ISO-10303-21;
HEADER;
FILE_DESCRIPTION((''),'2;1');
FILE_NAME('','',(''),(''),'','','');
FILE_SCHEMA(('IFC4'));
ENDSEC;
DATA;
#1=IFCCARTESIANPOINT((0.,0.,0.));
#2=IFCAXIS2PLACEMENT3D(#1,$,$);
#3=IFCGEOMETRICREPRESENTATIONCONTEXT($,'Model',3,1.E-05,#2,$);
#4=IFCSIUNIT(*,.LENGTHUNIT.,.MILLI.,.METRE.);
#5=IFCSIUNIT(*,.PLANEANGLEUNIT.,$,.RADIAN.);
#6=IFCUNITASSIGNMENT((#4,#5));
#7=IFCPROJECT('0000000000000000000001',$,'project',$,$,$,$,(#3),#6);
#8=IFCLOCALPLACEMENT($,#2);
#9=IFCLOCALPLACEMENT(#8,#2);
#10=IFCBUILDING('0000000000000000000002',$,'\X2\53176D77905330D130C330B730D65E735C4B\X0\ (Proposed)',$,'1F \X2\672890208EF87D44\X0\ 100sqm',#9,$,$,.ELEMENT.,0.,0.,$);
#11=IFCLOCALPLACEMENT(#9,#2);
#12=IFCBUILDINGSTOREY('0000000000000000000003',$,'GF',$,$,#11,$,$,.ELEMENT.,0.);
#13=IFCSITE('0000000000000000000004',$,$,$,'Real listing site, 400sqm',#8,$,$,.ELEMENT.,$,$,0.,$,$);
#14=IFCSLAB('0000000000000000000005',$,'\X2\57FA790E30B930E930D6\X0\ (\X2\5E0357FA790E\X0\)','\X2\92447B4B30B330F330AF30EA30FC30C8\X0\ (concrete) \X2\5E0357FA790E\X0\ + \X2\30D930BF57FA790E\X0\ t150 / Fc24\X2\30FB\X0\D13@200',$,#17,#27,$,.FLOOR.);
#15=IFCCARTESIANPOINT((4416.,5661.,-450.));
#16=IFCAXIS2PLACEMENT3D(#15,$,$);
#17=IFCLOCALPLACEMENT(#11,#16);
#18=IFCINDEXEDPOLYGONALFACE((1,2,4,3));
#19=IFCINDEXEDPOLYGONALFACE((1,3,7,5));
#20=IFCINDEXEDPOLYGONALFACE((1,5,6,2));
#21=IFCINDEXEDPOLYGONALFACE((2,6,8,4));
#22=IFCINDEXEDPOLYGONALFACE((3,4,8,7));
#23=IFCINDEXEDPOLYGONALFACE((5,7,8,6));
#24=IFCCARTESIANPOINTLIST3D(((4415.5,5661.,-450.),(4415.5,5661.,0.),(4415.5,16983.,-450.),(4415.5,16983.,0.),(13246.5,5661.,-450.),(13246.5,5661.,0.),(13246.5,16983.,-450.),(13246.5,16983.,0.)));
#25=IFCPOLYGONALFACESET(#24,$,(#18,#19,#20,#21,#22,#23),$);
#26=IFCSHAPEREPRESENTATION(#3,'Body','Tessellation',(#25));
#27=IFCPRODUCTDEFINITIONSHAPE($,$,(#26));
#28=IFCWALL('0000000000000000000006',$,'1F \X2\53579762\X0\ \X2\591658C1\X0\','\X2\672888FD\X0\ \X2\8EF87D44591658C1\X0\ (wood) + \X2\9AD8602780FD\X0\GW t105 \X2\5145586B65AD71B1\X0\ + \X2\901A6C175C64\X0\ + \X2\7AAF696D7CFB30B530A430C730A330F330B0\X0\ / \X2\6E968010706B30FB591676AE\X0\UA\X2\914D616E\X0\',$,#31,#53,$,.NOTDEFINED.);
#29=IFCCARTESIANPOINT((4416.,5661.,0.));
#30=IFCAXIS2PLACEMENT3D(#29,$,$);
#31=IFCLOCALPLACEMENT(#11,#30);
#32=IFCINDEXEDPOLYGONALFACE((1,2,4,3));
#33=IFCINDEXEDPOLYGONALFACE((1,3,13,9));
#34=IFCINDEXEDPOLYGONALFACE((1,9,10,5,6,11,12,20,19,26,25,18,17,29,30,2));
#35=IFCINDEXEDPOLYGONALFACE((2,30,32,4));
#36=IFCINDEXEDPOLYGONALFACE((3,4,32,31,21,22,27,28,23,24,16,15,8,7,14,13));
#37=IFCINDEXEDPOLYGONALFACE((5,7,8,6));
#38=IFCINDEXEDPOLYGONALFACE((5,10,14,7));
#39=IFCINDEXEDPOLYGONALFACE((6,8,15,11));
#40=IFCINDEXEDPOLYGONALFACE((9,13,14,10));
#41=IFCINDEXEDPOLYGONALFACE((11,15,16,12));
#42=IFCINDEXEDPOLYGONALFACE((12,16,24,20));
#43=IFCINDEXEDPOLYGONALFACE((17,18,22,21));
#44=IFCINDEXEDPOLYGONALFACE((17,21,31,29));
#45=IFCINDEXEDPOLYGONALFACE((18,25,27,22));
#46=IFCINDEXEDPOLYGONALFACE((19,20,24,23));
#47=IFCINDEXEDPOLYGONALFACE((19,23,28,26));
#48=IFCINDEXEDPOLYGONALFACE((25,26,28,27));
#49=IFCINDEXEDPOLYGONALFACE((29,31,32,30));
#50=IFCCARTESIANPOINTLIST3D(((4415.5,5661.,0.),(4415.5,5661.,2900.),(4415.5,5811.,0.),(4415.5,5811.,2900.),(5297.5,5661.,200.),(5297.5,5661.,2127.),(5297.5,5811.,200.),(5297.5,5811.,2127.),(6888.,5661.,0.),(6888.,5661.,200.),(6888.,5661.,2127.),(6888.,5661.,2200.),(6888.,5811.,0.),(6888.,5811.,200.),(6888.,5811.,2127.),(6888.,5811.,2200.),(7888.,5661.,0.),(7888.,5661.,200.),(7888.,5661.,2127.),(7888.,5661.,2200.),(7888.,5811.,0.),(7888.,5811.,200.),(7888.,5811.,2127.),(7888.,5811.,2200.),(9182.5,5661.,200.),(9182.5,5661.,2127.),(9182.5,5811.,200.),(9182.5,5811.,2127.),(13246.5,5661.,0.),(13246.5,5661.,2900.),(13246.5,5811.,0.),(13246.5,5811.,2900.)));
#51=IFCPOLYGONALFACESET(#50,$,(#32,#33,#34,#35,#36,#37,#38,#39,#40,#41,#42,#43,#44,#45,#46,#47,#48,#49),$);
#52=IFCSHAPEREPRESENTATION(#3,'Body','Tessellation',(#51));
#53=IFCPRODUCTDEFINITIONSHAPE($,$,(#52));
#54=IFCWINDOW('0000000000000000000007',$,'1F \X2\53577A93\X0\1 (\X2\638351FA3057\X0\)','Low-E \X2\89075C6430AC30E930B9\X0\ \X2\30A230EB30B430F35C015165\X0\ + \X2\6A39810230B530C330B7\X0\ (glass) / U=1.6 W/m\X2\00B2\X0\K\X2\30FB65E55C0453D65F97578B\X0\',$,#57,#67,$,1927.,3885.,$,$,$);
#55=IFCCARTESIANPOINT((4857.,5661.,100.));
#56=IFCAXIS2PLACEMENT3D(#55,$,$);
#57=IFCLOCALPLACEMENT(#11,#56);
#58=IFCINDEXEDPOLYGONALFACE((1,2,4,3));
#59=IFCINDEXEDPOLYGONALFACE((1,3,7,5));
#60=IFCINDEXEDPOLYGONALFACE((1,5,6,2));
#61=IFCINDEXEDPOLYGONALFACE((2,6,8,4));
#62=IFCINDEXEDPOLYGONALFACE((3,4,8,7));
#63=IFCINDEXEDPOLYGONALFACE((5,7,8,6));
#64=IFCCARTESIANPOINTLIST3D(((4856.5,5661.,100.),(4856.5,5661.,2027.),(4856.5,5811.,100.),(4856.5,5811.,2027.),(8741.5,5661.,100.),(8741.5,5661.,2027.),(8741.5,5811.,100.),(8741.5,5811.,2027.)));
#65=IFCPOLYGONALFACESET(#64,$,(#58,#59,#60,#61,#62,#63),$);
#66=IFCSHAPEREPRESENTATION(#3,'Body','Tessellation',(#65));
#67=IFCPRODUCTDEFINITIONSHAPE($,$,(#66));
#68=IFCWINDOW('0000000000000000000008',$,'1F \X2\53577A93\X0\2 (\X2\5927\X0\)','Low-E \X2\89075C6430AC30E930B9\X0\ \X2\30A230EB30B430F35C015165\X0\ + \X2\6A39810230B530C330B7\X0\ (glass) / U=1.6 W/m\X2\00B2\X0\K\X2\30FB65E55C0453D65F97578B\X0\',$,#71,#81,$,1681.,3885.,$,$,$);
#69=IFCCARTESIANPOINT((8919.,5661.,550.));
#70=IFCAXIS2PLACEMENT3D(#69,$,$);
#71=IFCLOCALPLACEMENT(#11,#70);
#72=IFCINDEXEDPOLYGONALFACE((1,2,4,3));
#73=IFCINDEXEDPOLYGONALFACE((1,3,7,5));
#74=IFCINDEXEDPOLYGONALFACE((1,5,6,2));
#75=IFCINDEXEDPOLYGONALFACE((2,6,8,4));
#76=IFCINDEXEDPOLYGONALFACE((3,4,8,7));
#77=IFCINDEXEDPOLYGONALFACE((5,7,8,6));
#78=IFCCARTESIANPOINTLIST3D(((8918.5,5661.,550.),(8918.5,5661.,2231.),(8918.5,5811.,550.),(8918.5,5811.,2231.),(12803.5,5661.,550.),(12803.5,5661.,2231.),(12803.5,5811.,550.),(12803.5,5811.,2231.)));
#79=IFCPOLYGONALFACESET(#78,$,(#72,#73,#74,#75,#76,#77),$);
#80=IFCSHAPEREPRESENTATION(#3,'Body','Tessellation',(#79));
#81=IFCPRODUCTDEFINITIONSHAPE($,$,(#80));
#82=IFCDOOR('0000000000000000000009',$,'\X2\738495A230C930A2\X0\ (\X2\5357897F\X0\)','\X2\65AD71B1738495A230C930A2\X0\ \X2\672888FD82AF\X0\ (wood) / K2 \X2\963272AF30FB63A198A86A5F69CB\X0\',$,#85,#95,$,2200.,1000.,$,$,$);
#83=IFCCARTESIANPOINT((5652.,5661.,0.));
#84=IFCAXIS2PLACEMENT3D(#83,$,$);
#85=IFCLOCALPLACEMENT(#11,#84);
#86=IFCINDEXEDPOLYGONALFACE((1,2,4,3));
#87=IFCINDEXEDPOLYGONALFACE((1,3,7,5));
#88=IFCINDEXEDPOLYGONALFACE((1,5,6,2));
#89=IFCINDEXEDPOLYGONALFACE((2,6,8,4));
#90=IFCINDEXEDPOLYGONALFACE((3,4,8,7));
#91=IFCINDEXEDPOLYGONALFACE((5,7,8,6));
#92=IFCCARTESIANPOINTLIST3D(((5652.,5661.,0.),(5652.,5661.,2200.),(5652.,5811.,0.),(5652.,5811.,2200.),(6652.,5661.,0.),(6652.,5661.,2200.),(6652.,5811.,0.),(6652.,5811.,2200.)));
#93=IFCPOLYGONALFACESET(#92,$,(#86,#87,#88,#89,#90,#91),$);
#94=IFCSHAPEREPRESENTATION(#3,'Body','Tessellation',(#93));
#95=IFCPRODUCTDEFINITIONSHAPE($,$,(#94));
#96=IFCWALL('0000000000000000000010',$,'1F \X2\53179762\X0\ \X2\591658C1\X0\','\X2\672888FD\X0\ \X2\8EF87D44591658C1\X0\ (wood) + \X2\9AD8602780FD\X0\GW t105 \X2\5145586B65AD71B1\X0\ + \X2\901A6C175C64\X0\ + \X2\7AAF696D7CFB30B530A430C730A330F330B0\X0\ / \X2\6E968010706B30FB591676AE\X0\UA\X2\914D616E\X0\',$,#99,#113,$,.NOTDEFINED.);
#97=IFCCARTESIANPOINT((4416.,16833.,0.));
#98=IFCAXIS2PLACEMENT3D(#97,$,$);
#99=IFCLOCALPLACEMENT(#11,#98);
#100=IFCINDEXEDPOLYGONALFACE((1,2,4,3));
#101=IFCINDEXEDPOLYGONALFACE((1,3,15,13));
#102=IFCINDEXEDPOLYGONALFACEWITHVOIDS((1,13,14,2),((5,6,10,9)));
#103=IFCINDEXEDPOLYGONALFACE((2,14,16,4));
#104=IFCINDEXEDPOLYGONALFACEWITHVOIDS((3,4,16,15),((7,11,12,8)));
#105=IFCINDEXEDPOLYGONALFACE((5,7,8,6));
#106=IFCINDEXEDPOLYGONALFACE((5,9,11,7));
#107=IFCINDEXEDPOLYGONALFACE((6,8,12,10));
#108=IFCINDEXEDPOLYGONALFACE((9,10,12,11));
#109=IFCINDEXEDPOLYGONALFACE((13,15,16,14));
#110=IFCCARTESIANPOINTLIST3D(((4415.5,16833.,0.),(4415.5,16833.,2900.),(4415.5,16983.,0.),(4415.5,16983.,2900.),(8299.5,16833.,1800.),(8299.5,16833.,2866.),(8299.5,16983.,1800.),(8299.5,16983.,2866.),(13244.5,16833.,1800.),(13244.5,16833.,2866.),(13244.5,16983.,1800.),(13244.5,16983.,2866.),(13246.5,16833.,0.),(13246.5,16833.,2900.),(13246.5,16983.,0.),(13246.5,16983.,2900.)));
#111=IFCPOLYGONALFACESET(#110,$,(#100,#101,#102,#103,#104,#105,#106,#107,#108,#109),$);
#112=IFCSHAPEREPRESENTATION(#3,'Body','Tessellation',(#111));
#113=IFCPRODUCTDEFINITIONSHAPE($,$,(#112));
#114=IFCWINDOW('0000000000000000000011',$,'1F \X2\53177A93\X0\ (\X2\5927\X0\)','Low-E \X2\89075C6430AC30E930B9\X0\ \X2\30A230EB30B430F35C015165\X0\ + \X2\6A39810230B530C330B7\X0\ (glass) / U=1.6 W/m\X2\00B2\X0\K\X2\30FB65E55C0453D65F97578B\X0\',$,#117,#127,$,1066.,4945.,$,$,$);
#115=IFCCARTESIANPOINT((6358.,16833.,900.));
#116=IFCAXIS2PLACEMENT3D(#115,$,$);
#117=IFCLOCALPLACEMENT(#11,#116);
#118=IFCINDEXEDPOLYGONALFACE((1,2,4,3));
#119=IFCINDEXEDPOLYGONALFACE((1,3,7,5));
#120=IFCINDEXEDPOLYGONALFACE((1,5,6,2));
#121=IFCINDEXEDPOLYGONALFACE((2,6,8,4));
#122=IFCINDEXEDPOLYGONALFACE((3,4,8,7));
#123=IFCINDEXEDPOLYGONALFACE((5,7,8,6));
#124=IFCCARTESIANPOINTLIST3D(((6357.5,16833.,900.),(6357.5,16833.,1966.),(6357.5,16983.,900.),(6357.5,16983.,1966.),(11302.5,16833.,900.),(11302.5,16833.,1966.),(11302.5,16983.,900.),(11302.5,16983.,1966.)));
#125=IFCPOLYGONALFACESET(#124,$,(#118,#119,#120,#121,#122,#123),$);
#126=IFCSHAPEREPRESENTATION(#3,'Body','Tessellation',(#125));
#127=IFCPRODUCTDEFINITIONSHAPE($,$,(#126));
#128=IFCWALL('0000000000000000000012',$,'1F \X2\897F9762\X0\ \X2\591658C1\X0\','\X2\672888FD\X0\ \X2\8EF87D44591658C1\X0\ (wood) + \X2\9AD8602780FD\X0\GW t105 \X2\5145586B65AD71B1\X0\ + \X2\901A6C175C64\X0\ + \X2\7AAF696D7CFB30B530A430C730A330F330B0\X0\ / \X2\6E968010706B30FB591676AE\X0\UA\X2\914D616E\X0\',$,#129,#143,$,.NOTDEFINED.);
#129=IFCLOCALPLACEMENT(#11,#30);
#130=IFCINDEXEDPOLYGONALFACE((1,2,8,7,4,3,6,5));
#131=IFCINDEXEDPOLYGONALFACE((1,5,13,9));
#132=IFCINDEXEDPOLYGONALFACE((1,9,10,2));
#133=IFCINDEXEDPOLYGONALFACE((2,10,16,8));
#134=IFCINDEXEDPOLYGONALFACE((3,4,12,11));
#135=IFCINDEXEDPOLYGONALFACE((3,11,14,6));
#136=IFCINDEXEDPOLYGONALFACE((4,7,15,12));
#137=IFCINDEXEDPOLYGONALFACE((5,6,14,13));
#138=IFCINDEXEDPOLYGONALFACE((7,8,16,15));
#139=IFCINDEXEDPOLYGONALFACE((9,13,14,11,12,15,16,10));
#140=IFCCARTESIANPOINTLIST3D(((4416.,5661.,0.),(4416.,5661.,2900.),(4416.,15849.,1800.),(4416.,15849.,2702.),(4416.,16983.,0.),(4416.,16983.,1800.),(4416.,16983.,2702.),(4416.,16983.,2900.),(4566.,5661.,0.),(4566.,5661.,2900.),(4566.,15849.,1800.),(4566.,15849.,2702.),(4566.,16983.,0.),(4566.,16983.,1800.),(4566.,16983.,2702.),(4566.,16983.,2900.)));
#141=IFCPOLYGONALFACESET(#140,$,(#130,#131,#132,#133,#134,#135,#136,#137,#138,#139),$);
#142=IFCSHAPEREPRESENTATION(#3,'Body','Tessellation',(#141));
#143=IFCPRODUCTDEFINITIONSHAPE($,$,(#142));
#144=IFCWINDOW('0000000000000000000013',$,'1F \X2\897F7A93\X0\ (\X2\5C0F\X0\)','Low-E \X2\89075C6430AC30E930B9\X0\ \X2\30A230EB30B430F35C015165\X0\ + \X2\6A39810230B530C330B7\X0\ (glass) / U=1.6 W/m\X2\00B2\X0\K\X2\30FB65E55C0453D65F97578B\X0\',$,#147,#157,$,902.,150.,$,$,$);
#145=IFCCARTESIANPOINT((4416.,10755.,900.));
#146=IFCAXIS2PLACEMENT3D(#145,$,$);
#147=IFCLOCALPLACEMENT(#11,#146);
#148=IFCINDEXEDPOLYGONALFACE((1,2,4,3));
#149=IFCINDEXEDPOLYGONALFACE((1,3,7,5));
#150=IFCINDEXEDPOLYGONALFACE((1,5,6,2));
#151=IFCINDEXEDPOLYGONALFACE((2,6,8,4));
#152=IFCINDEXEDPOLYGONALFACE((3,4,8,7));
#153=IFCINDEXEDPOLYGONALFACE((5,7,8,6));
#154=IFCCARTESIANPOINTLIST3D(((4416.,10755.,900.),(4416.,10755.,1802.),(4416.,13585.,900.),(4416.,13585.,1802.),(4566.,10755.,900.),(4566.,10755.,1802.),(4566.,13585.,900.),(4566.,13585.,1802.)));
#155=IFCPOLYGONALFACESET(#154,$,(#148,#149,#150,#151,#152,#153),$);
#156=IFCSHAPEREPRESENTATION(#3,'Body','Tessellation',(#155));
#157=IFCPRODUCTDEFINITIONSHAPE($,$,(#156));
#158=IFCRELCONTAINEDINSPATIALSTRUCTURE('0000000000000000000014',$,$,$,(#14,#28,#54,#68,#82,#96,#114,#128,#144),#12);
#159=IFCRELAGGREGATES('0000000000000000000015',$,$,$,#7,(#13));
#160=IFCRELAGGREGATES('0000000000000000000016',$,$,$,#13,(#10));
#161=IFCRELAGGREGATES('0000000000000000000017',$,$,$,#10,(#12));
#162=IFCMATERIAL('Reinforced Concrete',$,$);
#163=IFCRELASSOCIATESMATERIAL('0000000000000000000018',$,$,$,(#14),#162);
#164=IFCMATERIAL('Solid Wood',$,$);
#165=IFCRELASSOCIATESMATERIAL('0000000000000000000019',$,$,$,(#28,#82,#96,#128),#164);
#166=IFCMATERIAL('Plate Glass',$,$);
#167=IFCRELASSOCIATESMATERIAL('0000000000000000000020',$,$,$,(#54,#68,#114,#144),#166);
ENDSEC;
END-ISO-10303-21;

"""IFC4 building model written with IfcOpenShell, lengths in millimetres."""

from ifc_helpers import new_model, si_unit, frame, frame_2d, origin, place, context, project, spatial, rectangle, extrude, material, element, fill, save


model = new_model("IFC4")

# Units and contexts
model_context = context("Model", 3, precision=1e-05, world=origin())
ifc_project = project(units=[si_unit("LENGTHUNIT", "METRE", prefix="MILLI"), si_unit("PLANEANGLEUNIT", "RADIAN")], contexts=[model_context])

# Site, building, storey
site_placement = place(None, origin())
site = spatial("IfcSite", under=ifc_project, at=site_placement, ObjectType="Real listing site, 400sqm", CompositionType="ELEMENT", RefElevation=0.0)
building_placement = place(site_placement, origin())
building = spatial("IfcBuilding", under=site, at=building_placement, Name="北海道パッシブ平屋 (Proposed)", ObjectType="1F 木造軸組 100sqm", CompositionType="ELEMENT", ElevationOfRefHeight=0.0, ElevationOfTerrain=0.0)
storey_placement = place(building_placement, origin())
storey = spatial("IfcBuildingStorey", under=building, at=storey_placement, Name="GF", CompositionType="ELEMENT", Elevation=0.0)

# Slab
ifc_material_1 = material(Name="Reinforced Concrete")
slab_1_placement = place(storey_placement, frame((4416.0, 5661.0, -450.0)))
element("IfcSlab", 1, at=slab_1_placement, inside=storey, material=ifc_material_1, Name="基礎スラブ (布基礎)", Description="鉄筋コンクリート (concrete) 布基礎 + ベタ基礎 t150 / Fc24・D13@200", PredefinedType="FLOOR", context=model_context, shape_type="SweptSolid", body=[
    extrude(rectangle(XDim=8831.0, YDim=11322.0, at=frame_2d((4415.0, 5661.0))), frame((4416.0, 5661.0, -450.0)), (0.0, 0.0, 1.0), 450.0),
])
ifc_material_2 = material(Name="Solid Wood")

# Wall, openings, windows, door
wall_1_placement = place(storey_placement, frame((4416.0, 5661.0, 0.0)))
wall_1 = element("IfcWall", 2, at=wall_1_placement, inside=storey, material=ifc_material_2, Name="1F 南面 外壁", Description="木製 軸組外壁 (wood) + 高性能GW t105 充填断熱 + 通気層 + 窯業系サイディング / 準耐火・外皮UA配慮", PredefinedType="NOTDEFINED", context=model_context, shape_type="SweptSolid", body=[
    extrude(rectangle(XDim=8831.0, YDim=150.0, at=frame_2d((4415.0, 75.0))), frame((4416.0, 5661.0, 0.0)), (0.0, 0.0, 1.0), 2900.0),
])
opening_1_placement = place(storey_placement, frame((4857.0, 5661.0, 100.0)))
opening_1 = element("IfcOpeningElement", 3, at=opening_1_placement, cuts=wall_1, PredefinedType="NOTDEFINED", context=model_context, shape_type="SweptSolid", body=[
    extrude(rectangle(XDim=3885.0, YDim=150.0, at=frame_2d((1942.0, 75.0))), frame((4857.0, 5661.0, 100.0)), (0.0, 0.0, 1.0), 1927.0),
])
opening_2_placement = place(storey_placement, frame((8919.0, 5661.0, 550.0)))
opening_2 = element("IfcOpeningElement", 4, at=opening_2_placement, cuts=wall_1, PredefinedType="NOTDEFINED", context=model_context, shape_type="SweptSolid", body=[
    extrude(rectangle(XDim=3885.0, YDim=150.0, at=frame_2d((1942.0, 75.0))), frame((8919.0, 5661.0, 550.0)), (0.0, 0.0, 1.0), 1681.0),
])
opening_3_placement = place(storey_placement, frame((5652.0, 5661.0, 0.0)))
opening_3 = element("IfcOpeningElement", 5, at=opening_3_placement, cuts=wall_1, PredefinedType="NOTDEFINED", context=model_context, shape_type="SweptSolid", body=[
    extrude(rectangle(XDim=1000.0, YDim=150.0, at=frame_2d((500.0, 75.0))), frame((5652.0, 5661.0, 0.0)), (0.0, 0.0, 1.0), 2200.0),
])
ifc_material_3 = material(Name="Plate Glass")
window_1_placement = place(storey_placement, frame((4857.0, 5661.0, 100.0)))
window_1 = element("IfcWindow", 6, at=window_1_placement, inside=storey, material=ifc_material_3, Name="1F 南窓1 (掃出し)", Description="Low-E 複層ガラス アルゴン封入 + 樹脂サッシ (glass) / U=1.6 W/m²K・日射取得型", OverallHeight=1927.0, OverallWidth=3885.0, context=model_context, shape_type="SweptSolid", body=[
    extrude(rectangle(XDim=3885.0, YDim=150.0, at=frame_2d((1942.0, 75.0))), frame((4857.0, 5661.0, 100.0)), (0.0, 0.0, 1.0), 1927.0),
])
fill(opening_1, window_1)
window_2_placement = place(storey_placement, frame((8919.0, 5661.0, 550.0)))
window_2 = element("IfcWindow", 7, at=window_2_placement, inside=storey, material=ifc_material_3, Name="1F 南窓2 (大)", Description="Low-E 複層ガラス アルゴン封入 + 樹脂サッシ (glass) / U=1.6 W/m²K・日射取得型", OverallHeight=1681.0, OverallWidth=3885.0, context=model_context, shape_type="SweptSolid", body=[
    extrude(rectangle(XDim=3885.0, YDim=150.0, at=frame_2d((1942.0, 75.0))), frame((8919.0, 5661.0, 550.0)), (0.0, 0.0, 1.0), 1681.0),
])
fill(opening_2, window_2)
door_placement = place(storey_placement, frame((5652.0, 5661.0, 0.0)))
door = element("IfcDoor", 8, at=door_placement, inside=storey, material=ifc_material_2, Name="玄関ドア (南西)", Description="断熱玄関ドア 木製芯 (wood) / K2 防犯・採風機構", OverallHeight=2200.0, OverallWidth=1000.0, context=model_context, shape_type="SweptSolid", body=[
    extrude(rectangle(XDim=1000.0, YDim=150.0, at=frame_2d((500.0, 75.0))), frame((5652.0, 5661.0, 0.0)), (0.0, 0.0, 1.0), 2200.0),
])
fill(opening_3, door)

# Walls, openings, windows
wall_2_placement = place(storey_placement, frame((4416.0, 16833.0, 0.0)))
wall_2 = element("IfcWall", 9, at=wall_2_placement, inside=storey, material=ifc_material_2, Name="1F 北面 外壁", Description="木製 軸組外壁 (wood) + 高性能GW t105 充填断熱 + 通気層 + 窯業系サイディング / 準耐火・外皮UA配慮", PredefinedType="NOTDEFINED", context=model_context, shape_type="SweptSolid", body=[
    extrude(rectangle(XDim=8831.0, YDim=150.0, at=frame_2d((4415.0, 75.0))), frame((4416.0, 16833.0, 0.0)), (0.0, 0.0, 1.0), 2900.0),
])
opening_4_placement = place(storey_placement, frame((6358.0, 16833.0, 900.0)))
opening_4 = element("IfcOpeningElement", 10, at=opening_4_placement, cuts=wall_2, PredefinedType="NOTDEFINED", context=model_context, shape_type="SweptSolid", body=[
    extrude(rectangle(XDim=4945.0, YDim=150.0, at=frame_2d((2472.0, 75.0))), frame((6358.0, 16833.0, 900.0)), (0.0, 0.0, 1.0), 1066.0),
])
window_3_placement = place(storey_placement, frame((6358.0, 16833.0, 900.0)))
window_3 = element("IfcWindow", 11, at=window_3_placement, inside=storey, material=ifc_material_3, Name="1F 北窓 (大)", Description="Low-E 複層ガラス アルゴン封入 + 樹脂サッシ (glass) / U=1.6 W/m²K・日射取得型", OverallHeight=1066.0, OverallWidth=4945.0, context=model_context, shape_type="SweptSolid", body=[
    extrude(rectangle(XDim=4945.0, YDim=150.0, at=frame_2d((2472.0, 75.0))), frame((6358.0, 16833.0, 900.0)), (0.0, 0.0, 1.0), 1066.0),
])
fill(opening_4, window_3)
wall_3_placement = place(storey_placement, frame((4416.0, 5661.0, 0.0)))
wall_3 = element("IfcWall", 12, at=wall_3_placement, inside=storey, material=ifc_material_2, Name="1F 西面 外壁", Description="木製 軸組外壁 (wood) + 高性能GW t105 充填断熱 + 通気層 + 窯業系サイディング / 準耐火・外皮UA配慮", PredefinedType="NOTDEFINED", context=model_context, shape_type="SweptSolid", body=[
    extrude(rectangle(XDim=150.0, YDim=11322.0, at=frame_2d((75.0, 5661.0))), frame((4416.0, 5661.0, 0.0)), (0.0, 0.0, 1.0), 2900.0),
])
opening_5_placement = place(storey_placement, frame((4416.0, 10755.0, 900.0)))
opening_5 = element("IfcOpeningElement", 13, at=opening_5_placement, cuts=wall_3, PredefinedType="NOTDEFINED", context=model_context, shape_type="SweptSolid", body=[
    extrude(rectangle(XDim=150.0, YDim=2830.0, at=frame_2d((75.0, 1415.0))), frame((4416.0, 10755.0, 900.0)), (0.0, 0.0, 1.0), 902.0),
])
window_4_placement = place(storey_placement, frame((4416.0, 10755.0, 900.0)))
window_4 = element("IfcWindow", 14, at=window_4_placement, inside=storey, material=ifc_material_3, Name="1F 西窓 (小)", Description="Low-E 複層ガラス アルゴン封入 + 樹脂サッシ (glass) / U=1.6 W/m²K・日射取得型", OverallHeight=902.0, OverallWidth=150.0, context=model_context, shape_type="SweptSolid", body=[
    extrude(rectangle(XDim=150.0, YDim=2830.0, at=frame_2d((75.0, 1415.0))), frame((4416.0, 10755.0, 900.0)), (0.0, 0.0, 1.0), 902.0),
])
fill(opening_5, window_4)

save(model, "model.ifc")
